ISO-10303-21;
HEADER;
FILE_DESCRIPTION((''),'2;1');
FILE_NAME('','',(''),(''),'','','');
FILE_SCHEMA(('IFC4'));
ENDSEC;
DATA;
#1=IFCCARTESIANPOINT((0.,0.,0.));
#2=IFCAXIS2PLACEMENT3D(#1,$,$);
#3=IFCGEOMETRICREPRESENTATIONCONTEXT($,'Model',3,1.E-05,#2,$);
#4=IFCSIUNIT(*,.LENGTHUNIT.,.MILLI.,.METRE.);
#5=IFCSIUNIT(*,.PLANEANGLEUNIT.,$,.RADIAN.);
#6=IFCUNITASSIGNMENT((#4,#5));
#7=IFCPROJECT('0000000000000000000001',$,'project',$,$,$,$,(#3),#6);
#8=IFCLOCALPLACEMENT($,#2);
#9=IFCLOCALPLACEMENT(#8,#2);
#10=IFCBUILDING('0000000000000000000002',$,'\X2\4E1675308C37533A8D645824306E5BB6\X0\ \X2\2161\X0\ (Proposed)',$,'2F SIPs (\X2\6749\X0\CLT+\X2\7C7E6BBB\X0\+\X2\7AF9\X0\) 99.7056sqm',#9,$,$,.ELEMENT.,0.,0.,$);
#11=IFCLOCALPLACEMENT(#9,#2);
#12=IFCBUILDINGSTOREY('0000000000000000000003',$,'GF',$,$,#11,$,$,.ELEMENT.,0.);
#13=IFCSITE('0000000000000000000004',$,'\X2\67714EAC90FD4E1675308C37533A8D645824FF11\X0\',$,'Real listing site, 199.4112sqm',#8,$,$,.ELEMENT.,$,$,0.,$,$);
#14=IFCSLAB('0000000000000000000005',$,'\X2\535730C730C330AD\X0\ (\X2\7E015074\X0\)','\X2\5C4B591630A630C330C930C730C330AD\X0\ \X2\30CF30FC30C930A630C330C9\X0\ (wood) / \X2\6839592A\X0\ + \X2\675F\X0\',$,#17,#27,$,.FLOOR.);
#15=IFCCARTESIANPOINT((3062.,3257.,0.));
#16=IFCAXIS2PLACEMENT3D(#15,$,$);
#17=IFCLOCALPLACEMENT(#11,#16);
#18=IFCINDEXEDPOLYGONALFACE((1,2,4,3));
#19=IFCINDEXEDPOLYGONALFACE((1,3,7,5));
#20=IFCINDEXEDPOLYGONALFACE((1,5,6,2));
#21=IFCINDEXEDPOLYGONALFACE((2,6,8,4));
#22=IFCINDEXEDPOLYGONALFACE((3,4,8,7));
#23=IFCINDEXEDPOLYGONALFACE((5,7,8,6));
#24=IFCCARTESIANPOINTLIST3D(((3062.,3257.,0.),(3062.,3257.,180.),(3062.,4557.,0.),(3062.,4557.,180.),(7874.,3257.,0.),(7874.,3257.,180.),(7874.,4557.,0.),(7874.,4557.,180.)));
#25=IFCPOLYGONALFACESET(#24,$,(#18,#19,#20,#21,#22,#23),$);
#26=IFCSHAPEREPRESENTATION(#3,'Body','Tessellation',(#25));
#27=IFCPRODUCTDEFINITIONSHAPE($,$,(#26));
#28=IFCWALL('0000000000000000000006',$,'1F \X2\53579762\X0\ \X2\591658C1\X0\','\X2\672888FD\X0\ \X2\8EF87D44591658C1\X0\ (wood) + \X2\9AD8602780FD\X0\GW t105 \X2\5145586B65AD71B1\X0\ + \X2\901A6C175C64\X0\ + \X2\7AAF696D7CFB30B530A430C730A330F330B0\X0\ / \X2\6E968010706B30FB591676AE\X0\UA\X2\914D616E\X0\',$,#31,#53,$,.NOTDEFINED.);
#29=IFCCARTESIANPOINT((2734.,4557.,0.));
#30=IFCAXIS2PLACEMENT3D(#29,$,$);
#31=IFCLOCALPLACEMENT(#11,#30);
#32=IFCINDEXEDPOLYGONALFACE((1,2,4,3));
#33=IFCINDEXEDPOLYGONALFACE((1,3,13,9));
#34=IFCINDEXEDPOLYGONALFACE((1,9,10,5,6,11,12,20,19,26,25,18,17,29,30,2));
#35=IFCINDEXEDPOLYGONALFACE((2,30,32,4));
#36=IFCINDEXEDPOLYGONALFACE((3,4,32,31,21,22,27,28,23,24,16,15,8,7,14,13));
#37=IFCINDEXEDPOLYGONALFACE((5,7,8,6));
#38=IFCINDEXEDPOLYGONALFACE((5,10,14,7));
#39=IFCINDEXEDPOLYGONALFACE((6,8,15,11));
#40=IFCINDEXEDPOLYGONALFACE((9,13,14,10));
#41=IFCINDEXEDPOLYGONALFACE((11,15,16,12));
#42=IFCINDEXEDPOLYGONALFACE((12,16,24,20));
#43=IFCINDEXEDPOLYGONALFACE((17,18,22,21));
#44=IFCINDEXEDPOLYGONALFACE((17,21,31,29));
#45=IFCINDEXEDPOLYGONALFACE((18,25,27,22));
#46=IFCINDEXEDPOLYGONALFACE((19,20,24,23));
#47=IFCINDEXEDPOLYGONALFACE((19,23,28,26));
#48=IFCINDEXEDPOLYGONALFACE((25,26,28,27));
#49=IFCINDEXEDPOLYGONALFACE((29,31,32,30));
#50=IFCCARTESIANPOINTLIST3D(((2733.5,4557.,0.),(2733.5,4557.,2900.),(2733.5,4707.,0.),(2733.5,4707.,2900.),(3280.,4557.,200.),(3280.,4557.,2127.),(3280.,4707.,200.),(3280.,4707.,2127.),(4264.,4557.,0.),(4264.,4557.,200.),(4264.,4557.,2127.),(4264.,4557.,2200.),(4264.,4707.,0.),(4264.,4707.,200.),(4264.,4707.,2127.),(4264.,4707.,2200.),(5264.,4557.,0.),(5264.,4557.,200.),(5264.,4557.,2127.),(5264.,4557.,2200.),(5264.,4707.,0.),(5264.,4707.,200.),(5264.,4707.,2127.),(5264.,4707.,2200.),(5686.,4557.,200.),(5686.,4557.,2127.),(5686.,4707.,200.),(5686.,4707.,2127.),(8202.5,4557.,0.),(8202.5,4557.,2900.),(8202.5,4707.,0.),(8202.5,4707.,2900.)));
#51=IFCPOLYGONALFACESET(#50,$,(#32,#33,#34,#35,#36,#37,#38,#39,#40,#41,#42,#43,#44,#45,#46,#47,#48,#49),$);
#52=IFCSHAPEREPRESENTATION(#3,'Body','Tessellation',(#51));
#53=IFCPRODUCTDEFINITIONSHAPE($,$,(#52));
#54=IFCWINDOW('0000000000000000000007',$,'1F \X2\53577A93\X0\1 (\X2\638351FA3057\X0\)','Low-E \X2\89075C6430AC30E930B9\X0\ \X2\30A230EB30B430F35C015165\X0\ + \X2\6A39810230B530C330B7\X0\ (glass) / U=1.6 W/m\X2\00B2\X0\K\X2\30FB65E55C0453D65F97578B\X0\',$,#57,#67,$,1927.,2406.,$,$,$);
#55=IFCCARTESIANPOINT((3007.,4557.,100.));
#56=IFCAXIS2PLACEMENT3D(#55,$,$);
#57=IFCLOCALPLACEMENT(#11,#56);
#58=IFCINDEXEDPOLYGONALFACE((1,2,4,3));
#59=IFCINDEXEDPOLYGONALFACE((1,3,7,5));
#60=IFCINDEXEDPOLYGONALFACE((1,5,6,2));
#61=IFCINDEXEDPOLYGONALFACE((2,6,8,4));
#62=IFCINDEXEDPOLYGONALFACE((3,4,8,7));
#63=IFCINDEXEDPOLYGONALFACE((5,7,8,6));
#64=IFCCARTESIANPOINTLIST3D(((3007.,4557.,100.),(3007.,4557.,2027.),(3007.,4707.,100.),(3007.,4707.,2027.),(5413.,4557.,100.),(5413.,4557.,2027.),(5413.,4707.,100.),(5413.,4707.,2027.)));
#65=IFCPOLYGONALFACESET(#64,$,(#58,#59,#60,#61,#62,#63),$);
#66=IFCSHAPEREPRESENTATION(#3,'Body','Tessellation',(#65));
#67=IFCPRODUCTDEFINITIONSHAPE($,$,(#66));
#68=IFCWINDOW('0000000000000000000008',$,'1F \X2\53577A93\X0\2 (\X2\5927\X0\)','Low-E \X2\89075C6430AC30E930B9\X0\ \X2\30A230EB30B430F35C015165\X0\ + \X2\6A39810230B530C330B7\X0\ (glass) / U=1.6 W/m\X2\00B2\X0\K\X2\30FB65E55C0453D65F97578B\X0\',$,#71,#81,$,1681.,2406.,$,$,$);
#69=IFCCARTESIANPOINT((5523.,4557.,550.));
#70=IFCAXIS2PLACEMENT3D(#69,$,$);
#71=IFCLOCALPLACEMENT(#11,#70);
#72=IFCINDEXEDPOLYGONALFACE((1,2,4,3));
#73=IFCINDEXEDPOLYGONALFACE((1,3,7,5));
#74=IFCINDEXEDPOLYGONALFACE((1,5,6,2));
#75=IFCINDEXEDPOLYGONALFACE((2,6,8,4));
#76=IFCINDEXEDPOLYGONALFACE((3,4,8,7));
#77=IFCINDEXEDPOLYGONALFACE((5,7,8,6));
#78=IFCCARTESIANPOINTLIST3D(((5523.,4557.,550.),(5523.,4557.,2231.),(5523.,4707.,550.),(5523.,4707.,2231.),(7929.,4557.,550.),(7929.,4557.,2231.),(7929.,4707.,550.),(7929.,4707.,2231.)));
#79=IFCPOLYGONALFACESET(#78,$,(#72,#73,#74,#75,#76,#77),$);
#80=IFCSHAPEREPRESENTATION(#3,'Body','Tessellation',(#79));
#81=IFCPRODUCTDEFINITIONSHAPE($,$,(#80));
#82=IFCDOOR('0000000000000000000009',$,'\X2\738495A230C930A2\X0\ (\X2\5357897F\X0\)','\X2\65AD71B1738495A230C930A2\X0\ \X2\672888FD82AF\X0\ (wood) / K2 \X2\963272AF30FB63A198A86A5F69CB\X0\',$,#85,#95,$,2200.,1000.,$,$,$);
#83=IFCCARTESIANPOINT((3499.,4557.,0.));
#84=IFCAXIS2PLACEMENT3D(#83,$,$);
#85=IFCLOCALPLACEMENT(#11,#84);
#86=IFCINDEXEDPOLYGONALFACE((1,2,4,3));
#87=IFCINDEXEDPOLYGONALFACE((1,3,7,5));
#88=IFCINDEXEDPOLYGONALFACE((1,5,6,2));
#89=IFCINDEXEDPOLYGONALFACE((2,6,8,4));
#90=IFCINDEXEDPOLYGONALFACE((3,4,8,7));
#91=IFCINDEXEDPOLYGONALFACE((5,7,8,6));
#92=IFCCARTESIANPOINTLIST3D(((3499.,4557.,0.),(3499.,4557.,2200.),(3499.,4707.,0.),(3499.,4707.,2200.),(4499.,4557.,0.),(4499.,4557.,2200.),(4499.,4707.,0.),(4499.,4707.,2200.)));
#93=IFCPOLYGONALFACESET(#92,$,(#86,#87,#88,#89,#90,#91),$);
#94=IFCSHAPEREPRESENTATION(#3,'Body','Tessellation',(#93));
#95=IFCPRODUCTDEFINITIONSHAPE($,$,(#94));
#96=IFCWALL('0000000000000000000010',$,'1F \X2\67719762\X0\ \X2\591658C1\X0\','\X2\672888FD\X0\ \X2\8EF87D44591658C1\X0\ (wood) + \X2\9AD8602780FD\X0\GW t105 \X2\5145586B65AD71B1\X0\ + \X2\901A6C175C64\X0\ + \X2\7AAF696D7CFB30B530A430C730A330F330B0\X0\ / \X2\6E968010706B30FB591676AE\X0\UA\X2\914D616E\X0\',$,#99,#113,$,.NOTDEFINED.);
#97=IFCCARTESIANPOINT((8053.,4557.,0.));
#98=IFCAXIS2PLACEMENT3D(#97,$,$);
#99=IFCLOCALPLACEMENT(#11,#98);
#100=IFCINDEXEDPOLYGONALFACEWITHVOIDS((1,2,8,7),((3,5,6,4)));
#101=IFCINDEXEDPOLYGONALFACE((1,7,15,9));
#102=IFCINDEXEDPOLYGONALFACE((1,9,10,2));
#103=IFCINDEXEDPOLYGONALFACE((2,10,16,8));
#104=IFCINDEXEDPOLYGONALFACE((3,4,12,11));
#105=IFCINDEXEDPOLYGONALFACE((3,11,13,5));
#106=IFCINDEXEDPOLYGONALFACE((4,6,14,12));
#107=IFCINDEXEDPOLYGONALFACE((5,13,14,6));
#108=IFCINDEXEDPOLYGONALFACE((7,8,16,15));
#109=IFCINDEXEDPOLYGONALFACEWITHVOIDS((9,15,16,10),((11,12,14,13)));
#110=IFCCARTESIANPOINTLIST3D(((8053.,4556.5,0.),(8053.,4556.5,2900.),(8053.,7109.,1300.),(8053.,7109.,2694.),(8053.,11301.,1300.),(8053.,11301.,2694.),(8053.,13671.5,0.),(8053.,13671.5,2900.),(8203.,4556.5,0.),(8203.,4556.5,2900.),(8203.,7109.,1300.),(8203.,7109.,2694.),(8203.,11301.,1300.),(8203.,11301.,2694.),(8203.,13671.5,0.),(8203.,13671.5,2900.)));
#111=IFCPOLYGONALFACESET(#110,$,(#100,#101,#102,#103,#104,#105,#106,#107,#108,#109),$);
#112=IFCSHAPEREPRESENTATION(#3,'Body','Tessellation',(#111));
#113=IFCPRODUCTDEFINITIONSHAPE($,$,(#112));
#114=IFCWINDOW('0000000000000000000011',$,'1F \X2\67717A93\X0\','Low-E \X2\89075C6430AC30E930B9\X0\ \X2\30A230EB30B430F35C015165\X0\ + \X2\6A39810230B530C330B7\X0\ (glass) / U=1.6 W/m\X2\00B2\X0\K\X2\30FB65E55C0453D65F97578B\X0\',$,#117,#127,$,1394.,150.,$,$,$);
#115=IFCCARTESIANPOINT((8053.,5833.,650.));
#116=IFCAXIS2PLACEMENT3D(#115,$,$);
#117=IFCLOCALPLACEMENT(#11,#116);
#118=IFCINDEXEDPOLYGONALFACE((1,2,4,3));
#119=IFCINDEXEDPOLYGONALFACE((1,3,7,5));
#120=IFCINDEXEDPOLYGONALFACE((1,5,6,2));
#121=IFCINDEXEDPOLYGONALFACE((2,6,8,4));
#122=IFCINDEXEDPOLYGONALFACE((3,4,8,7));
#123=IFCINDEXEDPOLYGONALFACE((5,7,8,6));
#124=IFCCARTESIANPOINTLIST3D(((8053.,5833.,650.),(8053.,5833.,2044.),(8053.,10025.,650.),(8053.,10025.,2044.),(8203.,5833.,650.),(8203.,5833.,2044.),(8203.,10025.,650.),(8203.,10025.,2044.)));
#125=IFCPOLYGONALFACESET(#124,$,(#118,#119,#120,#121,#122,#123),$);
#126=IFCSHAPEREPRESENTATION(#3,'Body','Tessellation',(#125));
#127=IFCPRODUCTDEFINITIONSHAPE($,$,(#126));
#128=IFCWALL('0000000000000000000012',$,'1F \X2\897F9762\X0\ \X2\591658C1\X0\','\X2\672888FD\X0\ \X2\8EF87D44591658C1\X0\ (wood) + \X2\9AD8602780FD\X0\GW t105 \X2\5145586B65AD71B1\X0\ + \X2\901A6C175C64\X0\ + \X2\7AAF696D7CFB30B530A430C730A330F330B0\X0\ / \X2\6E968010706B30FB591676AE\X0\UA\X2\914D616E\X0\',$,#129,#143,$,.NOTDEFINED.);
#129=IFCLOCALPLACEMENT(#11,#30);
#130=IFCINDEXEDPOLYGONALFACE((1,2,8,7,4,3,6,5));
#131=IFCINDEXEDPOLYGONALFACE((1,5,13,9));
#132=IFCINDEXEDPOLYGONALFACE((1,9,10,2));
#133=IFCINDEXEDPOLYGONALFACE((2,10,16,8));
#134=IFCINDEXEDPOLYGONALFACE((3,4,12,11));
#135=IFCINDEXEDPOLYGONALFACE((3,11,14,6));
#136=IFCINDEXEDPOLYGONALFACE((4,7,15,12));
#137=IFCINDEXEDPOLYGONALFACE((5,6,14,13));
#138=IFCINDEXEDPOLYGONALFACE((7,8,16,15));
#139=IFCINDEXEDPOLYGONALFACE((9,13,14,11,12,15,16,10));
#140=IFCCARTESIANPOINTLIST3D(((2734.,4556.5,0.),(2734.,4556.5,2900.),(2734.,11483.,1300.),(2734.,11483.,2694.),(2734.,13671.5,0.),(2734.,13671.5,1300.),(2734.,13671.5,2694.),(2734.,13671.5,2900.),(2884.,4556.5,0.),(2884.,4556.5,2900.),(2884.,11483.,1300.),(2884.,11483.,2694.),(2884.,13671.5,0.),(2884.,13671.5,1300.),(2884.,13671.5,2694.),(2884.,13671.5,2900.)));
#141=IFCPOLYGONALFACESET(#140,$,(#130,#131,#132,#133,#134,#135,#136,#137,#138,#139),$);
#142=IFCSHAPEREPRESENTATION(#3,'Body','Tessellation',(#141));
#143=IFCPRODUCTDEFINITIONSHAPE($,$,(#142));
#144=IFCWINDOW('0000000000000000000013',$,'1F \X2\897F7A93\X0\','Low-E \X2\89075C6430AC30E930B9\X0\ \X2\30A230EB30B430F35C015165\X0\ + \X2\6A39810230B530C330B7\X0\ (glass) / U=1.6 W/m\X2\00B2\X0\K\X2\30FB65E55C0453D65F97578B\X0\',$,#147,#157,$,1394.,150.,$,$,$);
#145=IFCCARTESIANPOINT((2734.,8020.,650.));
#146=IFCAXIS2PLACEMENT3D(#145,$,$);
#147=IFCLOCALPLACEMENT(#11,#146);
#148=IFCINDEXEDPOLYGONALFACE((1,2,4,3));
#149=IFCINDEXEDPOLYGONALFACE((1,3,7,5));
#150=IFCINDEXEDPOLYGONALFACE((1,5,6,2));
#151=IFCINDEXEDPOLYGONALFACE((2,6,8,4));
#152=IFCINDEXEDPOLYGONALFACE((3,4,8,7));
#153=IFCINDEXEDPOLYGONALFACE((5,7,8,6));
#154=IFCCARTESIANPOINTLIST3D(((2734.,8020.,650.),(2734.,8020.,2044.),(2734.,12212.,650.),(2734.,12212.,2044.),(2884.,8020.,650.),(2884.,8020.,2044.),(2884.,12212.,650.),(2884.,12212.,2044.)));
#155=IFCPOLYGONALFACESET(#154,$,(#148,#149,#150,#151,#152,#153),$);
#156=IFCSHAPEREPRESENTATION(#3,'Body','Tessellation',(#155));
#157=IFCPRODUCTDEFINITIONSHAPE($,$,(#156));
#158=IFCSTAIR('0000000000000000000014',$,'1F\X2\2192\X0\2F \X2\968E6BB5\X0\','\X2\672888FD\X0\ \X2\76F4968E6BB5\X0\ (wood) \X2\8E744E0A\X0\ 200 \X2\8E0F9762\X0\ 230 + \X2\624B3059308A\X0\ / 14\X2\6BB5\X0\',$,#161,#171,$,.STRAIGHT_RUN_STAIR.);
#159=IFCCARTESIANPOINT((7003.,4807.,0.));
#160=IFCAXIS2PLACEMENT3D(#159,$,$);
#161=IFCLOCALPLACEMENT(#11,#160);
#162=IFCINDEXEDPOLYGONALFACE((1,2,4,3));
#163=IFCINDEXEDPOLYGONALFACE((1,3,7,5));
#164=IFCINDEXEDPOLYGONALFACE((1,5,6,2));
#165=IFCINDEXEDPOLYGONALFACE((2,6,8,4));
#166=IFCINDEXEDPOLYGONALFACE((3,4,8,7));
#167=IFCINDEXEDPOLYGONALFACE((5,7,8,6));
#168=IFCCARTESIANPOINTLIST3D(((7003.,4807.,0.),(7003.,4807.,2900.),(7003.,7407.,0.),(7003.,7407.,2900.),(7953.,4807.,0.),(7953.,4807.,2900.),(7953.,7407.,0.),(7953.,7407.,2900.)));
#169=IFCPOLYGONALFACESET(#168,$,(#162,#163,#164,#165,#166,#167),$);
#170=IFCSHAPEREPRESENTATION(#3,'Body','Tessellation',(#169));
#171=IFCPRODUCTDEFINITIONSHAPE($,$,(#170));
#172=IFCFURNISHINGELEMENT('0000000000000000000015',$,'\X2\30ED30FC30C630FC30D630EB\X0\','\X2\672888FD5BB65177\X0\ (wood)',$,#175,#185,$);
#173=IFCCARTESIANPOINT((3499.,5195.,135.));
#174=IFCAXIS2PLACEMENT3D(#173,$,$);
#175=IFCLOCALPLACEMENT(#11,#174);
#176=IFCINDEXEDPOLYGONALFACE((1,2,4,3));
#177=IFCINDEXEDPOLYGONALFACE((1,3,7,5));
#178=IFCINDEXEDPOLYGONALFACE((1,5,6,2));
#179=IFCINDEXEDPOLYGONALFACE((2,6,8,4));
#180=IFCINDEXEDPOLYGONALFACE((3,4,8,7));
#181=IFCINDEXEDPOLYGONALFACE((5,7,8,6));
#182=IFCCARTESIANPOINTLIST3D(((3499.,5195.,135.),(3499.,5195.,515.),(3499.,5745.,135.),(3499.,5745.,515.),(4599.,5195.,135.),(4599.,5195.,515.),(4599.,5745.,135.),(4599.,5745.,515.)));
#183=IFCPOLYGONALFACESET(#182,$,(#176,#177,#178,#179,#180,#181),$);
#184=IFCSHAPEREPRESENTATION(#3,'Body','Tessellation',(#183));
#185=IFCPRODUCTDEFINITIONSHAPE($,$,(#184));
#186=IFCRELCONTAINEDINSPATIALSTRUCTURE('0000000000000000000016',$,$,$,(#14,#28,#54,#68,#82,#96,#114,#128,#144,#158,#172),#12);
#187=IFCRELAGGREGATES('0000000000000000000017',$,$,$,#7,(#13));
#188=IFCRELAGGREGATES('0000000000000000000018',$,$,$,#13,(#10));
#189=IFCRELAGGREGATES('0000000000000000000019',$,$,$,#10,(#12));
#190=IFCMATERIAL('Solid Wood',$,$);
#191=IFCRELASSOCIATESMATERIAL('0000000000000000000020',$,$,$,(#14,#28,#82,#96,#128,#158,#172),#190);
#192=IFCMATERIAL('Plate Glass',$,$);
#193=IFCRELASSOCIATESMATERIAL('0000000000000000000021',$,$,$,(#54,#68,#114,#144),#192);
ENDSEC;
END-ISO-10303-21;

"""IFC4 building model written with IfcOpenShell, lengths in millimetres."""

from ifc_helpers import new_model, si_unit, frame, frame_2d, origin, place, context, project, spatial, rectangle, extrude, material, element, fill, save


model = new_model("IFC4")

# Units and contexts
model_context = context("Model", 3, precision=1e-05, world=origin())
ifc_project = project(units=[si_unit("LENGTHUNIT", "METRE", prefix="MILLI"), si_unit("PLANEANGLEUNIT", "RADIAN")], contexts=[model_context])

# Site, building, storey
site_placement = place(None, origin())
site = spatial("IfcSite", under=ifc_project, at=site_placement, Name="東京都世田谷区赤堤１", ObjectType="Real listing site, 199.4112sqm", CompositionType="ELEMENT", RefElevation=0.0)
building_placement = place(site_placement, origin())
building = spatial("IfcBuilding", under=site, at=building_placement, Name="世田谷区赤堤の家 Ⅱ (Proposed)", ObjectType="2F SIPs (杉CLT+籾殻+竹) 99.7056sqm", CompositionType="ELEMENT", ElevationOfRefHeight=0.0, ElevationOfTerrain=0.0)
storey_placement = place(building_placement, origin())
storey = spatial("IfcBuildingStorey", under=building, at=storey_placement, Name="GF", CompositionType="ELEMENT", Elevation=0.0)

# Slab
ifc_material_1 = material(Name="Solid Wood")
slab_1_placement = place(storey_placement, frame((3062.0, 3257.0, 0.0)))
element("IfcSlab", 1, at=slab_1_placement, inside=storey, material=ifc_material_1, Name="南デッキ (縁側)", Description="屋外ウッドデッキ ハードウッド (wood) / 根太 + 束", PredefinedType="FLOOR", context=model_context, shape_type="SweptSolid", body=[
    extrude(rectangle(XDim=4812.0, YDim=1300.0, at=frame_2d((2406.0, 650.0))), frame((3062.0, 3257.0, 0.0)), (0.0, 0.0, 1.0), 180.0),
])

# Wall, openings, windows, door
wall_1_placement = place(storey_placement, frame((2734.0, 4557.0, 0.0)))
wall_1 = element("IfcWall", 2, at=wall_1_placement, inside=storey, material=ifc_material_1, Name="1F 南面 外壁", Description="木製 軸組外壁 (wood) + 高性能GW t105 充填断熱 + 通気層 + 窯業系サイディング / 準耐火・外皮UA配慮", PredefinedType="NOTDEFINED", context=model_context, shape_type="SweptSolid", body=[
    extrude(rectangle(XDim=5469.0, YDim=150.0, at=frame_2d((2734.0, 75.0))), frame((2734.0, 4557.0, 0.0)), (0.0, 0.0, 1.0), 2900.0),
])
opening_1_placement = place(storey_placement, frame((3007.0, 4557.0, 100.0)))
opening_1 = element("IfcOpeningElement", 3, at=opening_1_placement, cuts=wall_1, PredefinedType="NOTDEFINED", context=model_context, shape_type="SweptSolid", body=[
    extrude(rectangle(XDim=2406.0, YDim=150.0, at=frame_2d((1203.0, 75.0))), frame((3007.0, 4557.0, 100.0)), (0.0, 0.0, 1.0), 1927.0),
])
opening_2_placement = place(storey_placement, frame((5523.0, 4557.0, 550.0)))
opening_2 = element("IfcOpeningElement", 4, at=opening_2_placement, cuts=wall_1, PredefinedType="NOTDEFINED", context=model_context, shape_type="SweptSolid", body=[
    extrude(rectangle(XDim=2406.0, YDim=150.0, at=frame_2d((1203.0, 75.0))), frame((5523.0, 4557.0, 550.0)), (0.0, 0.0, 1.0), 1681.0),
])
opening_3_placement = place(storey_placement, frame((3499.0, 4557.0, 0.0)))
opening_3 = element("IfcOpeningElement", 5, at=opening_3_placement, cuts=wall_1, PredefinedType="NOTDEFINED", context=model_context, shape_type="SweptSolid", body=[
    extrude(rectangle(XDim=1000.0, YDim=150.0, at=frame_2d((500.0, 75.0))), frame((3499.0, 4557.0, 0.0)), (0.0, 0.0, 1.0), 2200.0),
])
ifc_material_2 = material(Name="Plate Glass")
window_1_placement = place(storey_placement, frame((3007.0, 4557.0, 100.0)))
window_1 = element("IfcWindow", 6, at=window_1_placement, inside=storey, material=ifc_material_2, Name="1F 南窓1 (掃出し)", Description="Low-E 複層ガラス アルゴン封入 + 樹脂サッシ (glass) / U=1.6 W/m²K・日射取得型", OverallHeight=1927.0, OverallWidth=2406.0, context=model_context, shape_type="SweptSolid", body=[
    extrude(rectangle(XDim=2406.0, YDim=150.0, at=frame_2d((1203.0, 75.0))), frame((3007.0, 4557.0, 100.0)), (0.0, 0.0, 1.0), 1927.0),
])
fill(opening_1, window_1)
window_2_placement = place(storey_placement, frame((5523.0, 4557.0, 550.0)))
window_2 = element("IfcWindow", 7, at=window_2_placement, inside=storey, material=ifc_material_2, Name="1F 南窓2 (大)", Description="Low-E 複層ガラス アルゴン封入 + 樹脂サッシ (glass) / U=1.6 W/m²K・日射取得型", OverallHeight=1681.0, OverallWidth=2406.0, context=model_context, shape_type="SweptSolid", body=[
    extrude(rectangle(XDim=2406.0, YDim=150.0, at=frame_2d((1203.0, 75.0))), frame((5523.0, 4557.0, 550.0)), (0.0, 0.0, 1.0), 1681.0),
])
fill(opening_2, window_2)
door_placement = place(storey_placement, frame((3499.0, 4557.0, 0.0)))
door = element("IfcDoor", 8, at=door_placement, inside=storey, material=ifc_material_1, Name="玄関ドア (南西)", Description="断熱玄関ドア 木製芯 (wood) / K2 防犯・採風機構", OverallHeight=2200.0, OverallWidth=1000.0, context=model_context, shape_type="SweptSolid", body=[
    extrude(rectangle(XDim=1000.0, YDim=150.0, at=frame_2d((500.0, 75.0))), frame((3499.0, 4557.0, 0.0)), (0.0, 0.0, 1.0), 2200.0),
])
fill(opening_3, door)

# Walls, openings, windows
wall_2_placement = place(storey_placement, frame((8053.0, 4557.0, 0.0)))
wall_2 = element("IfcWall", 9, at=wall_2_placement, inside=storey, material=ifc_material_1, Name="1F 東面 外壁", Description="木製 軸組外壁 (wood) + 高性能GW t105 充填断熱 + 通気層 + 窯業系サイディング / 準耐火・外皮UA配慮", PredefinedType="NOTDEFINED", context=model_context, shape_type="SweptSolid", body=[
    extrude(rectangle(XDim=150.0, YDim=9115.0, at=frame_2d((75.0, 4557.0))), frame((8053.0, 4557.0, 0.0)), (0.0, 0.0, 1.0), 2900.0),
])
opening_4_placement = place(storey_placement, frame((8053.0, 5833.0, 650.0)))
opening_4 = element("IfcOpeningElement", 10, at=opening_4_placement, cuts=wall_2, PredefinedType="NOTDEFINED", context=model_context, shape_type="SweptSolid", body=[
    extrude(rectangle(XDim=150.0, YDim=4192.0, at=frame_2d((75.0, 2096.0))), frame((8053.0, 5833.0, 650.0)), (0.0, 0.0, 1.0), 1394.0),
])
window_3_placement = place(storey_placement, frame((8053.0, 5833.0, 650.0)))
window_3 = element("IfcWindow", 11, at=window_3_placement, inside=storey, material=ifc_material_2, Name="1F 東窓", Description="Low-E 複層ガラス アルゴン封入 + 樹脂サッシ (glass) / U=1.6 W/m²K・日射取得型", OverallHeight=1394.0, OverallWidth=150.0, context=model_context, shape_type="SweptSolid", body=[
    extrude(rectangle(XDim=150.0, YDim=4192.0, at=frame_2d((75.0, 2096.0))), frame((8053.0, 5833.0, 650.0)), (0.0, 0.0, 1.0), 1394.0),
])
fill(opening_4, window_3)
wall_3_placement = place(storey_placement, frame((2734.0, 4557.0, 0.0)))
wall_3 = element("IfcWall", 12, at=wall_3_placement, inside=storey, material=ifc_material_1, Name="1F 西面 外壁", Description="木製 軸組外壁 (wood) + 高性能GW t105 充填断熱 + 通気層 + 窯業系サイディング / 準耐火・外皮UA配慮", PredefinedType="NOTDEFINED", context=model_context, shape_type="SweptSolid", body=[
    extrude(rectangle(XDim=150.0, YDim=9115.0, at=frame_2d((75.0, 4557.0))), frame((2734.0, 4557.0, 0.0)), (0.0, 0.0, 1.0), 2900.0),
])
opening_5_placement = place(storey_placement, frame((2734.0, 8020.0, 650.0)))
opening_5 = element("IfcOpeningElement", 13, at=opening_5_placement, cuts=wall_3, PredefinedType="NOTDEFINED", context=model_context, shape_type="SweptSolid", body=[
    extrude(rectangle(XDim=150.0, YDim=4192.0, at=frame_2d((75.0, 2096.0))), frame((2734.0, 8020.0, 650.0)), (0.0, 0.0, 1.0), 1394.0),
])
window_4_placement = place(storey_placement, frame((2734.0, 8020.0, 650.0)))
window_4 = element("IfcWindow", 14, at=window_4_placement, inside=storey, material=ifc_material_2, Name="1F 西窓", Description="Low-E 複層ガラス アルゴン封入 + 樹脂サッシ (glass) / U=1.6 W/m²K・日射取得型", OverallHeight=1394.0, OverallWidth=150.0, context=model_context, shape_type="SweptSolid", body=[
    extrude(rectangle(XDim=150.0, YDim=4192.0, at=frame_2d((75.0, 2096.0))), frame((2734.0, 8020.0, 650.0)), (0.0, 0.0, 1.0), 1394.0),
])
fill(opening_5, window_4)

# Stair
stair_placement = place(storey_placement, frame((7003.0, 4807.0, 0.0)))
element("IfcStair", 15, at=stair_placement, inside=storey, material=ifc_material_1, Name="1F→2F 階段", Description="木製 直階段 (wood) 蹴上 200 踏面 230 + 手すり / 14段", PredefinedType="STRAIGHT_RUN_STAIR", context=model_context, shape_type="SweptSolid", body=[
    extrude(rectangle(XDim=950.0, YDim=2600.0, at=frame_2d((475.0, 1300.0))), frame((7003.0, 4807.0, 0.0)), (0.0, 0.0, 1.0), 2900.0),
])

# Furnishing element
furnishing_1_placement = place(storey_placement, frame((3499.0, 5195.0, 135.0)))
element("IfcFurnishingElement", 16, at=furnishing_1_placement, inside=storey, material=ifc_material_1, Name="ローテーブル", Description="木製家具 (wood)", context=model_context, shape_type="SweptSolid", body=[
    extrude(rectangle(XDim=1100.0, YDim=550.0, at=frame_2d((550.0, 275.0))), frame((3499.0, 5195.0, 135.0)), (0.0, 0.0, 1.0), 380.0),
])

save(model, "model.ifc")
